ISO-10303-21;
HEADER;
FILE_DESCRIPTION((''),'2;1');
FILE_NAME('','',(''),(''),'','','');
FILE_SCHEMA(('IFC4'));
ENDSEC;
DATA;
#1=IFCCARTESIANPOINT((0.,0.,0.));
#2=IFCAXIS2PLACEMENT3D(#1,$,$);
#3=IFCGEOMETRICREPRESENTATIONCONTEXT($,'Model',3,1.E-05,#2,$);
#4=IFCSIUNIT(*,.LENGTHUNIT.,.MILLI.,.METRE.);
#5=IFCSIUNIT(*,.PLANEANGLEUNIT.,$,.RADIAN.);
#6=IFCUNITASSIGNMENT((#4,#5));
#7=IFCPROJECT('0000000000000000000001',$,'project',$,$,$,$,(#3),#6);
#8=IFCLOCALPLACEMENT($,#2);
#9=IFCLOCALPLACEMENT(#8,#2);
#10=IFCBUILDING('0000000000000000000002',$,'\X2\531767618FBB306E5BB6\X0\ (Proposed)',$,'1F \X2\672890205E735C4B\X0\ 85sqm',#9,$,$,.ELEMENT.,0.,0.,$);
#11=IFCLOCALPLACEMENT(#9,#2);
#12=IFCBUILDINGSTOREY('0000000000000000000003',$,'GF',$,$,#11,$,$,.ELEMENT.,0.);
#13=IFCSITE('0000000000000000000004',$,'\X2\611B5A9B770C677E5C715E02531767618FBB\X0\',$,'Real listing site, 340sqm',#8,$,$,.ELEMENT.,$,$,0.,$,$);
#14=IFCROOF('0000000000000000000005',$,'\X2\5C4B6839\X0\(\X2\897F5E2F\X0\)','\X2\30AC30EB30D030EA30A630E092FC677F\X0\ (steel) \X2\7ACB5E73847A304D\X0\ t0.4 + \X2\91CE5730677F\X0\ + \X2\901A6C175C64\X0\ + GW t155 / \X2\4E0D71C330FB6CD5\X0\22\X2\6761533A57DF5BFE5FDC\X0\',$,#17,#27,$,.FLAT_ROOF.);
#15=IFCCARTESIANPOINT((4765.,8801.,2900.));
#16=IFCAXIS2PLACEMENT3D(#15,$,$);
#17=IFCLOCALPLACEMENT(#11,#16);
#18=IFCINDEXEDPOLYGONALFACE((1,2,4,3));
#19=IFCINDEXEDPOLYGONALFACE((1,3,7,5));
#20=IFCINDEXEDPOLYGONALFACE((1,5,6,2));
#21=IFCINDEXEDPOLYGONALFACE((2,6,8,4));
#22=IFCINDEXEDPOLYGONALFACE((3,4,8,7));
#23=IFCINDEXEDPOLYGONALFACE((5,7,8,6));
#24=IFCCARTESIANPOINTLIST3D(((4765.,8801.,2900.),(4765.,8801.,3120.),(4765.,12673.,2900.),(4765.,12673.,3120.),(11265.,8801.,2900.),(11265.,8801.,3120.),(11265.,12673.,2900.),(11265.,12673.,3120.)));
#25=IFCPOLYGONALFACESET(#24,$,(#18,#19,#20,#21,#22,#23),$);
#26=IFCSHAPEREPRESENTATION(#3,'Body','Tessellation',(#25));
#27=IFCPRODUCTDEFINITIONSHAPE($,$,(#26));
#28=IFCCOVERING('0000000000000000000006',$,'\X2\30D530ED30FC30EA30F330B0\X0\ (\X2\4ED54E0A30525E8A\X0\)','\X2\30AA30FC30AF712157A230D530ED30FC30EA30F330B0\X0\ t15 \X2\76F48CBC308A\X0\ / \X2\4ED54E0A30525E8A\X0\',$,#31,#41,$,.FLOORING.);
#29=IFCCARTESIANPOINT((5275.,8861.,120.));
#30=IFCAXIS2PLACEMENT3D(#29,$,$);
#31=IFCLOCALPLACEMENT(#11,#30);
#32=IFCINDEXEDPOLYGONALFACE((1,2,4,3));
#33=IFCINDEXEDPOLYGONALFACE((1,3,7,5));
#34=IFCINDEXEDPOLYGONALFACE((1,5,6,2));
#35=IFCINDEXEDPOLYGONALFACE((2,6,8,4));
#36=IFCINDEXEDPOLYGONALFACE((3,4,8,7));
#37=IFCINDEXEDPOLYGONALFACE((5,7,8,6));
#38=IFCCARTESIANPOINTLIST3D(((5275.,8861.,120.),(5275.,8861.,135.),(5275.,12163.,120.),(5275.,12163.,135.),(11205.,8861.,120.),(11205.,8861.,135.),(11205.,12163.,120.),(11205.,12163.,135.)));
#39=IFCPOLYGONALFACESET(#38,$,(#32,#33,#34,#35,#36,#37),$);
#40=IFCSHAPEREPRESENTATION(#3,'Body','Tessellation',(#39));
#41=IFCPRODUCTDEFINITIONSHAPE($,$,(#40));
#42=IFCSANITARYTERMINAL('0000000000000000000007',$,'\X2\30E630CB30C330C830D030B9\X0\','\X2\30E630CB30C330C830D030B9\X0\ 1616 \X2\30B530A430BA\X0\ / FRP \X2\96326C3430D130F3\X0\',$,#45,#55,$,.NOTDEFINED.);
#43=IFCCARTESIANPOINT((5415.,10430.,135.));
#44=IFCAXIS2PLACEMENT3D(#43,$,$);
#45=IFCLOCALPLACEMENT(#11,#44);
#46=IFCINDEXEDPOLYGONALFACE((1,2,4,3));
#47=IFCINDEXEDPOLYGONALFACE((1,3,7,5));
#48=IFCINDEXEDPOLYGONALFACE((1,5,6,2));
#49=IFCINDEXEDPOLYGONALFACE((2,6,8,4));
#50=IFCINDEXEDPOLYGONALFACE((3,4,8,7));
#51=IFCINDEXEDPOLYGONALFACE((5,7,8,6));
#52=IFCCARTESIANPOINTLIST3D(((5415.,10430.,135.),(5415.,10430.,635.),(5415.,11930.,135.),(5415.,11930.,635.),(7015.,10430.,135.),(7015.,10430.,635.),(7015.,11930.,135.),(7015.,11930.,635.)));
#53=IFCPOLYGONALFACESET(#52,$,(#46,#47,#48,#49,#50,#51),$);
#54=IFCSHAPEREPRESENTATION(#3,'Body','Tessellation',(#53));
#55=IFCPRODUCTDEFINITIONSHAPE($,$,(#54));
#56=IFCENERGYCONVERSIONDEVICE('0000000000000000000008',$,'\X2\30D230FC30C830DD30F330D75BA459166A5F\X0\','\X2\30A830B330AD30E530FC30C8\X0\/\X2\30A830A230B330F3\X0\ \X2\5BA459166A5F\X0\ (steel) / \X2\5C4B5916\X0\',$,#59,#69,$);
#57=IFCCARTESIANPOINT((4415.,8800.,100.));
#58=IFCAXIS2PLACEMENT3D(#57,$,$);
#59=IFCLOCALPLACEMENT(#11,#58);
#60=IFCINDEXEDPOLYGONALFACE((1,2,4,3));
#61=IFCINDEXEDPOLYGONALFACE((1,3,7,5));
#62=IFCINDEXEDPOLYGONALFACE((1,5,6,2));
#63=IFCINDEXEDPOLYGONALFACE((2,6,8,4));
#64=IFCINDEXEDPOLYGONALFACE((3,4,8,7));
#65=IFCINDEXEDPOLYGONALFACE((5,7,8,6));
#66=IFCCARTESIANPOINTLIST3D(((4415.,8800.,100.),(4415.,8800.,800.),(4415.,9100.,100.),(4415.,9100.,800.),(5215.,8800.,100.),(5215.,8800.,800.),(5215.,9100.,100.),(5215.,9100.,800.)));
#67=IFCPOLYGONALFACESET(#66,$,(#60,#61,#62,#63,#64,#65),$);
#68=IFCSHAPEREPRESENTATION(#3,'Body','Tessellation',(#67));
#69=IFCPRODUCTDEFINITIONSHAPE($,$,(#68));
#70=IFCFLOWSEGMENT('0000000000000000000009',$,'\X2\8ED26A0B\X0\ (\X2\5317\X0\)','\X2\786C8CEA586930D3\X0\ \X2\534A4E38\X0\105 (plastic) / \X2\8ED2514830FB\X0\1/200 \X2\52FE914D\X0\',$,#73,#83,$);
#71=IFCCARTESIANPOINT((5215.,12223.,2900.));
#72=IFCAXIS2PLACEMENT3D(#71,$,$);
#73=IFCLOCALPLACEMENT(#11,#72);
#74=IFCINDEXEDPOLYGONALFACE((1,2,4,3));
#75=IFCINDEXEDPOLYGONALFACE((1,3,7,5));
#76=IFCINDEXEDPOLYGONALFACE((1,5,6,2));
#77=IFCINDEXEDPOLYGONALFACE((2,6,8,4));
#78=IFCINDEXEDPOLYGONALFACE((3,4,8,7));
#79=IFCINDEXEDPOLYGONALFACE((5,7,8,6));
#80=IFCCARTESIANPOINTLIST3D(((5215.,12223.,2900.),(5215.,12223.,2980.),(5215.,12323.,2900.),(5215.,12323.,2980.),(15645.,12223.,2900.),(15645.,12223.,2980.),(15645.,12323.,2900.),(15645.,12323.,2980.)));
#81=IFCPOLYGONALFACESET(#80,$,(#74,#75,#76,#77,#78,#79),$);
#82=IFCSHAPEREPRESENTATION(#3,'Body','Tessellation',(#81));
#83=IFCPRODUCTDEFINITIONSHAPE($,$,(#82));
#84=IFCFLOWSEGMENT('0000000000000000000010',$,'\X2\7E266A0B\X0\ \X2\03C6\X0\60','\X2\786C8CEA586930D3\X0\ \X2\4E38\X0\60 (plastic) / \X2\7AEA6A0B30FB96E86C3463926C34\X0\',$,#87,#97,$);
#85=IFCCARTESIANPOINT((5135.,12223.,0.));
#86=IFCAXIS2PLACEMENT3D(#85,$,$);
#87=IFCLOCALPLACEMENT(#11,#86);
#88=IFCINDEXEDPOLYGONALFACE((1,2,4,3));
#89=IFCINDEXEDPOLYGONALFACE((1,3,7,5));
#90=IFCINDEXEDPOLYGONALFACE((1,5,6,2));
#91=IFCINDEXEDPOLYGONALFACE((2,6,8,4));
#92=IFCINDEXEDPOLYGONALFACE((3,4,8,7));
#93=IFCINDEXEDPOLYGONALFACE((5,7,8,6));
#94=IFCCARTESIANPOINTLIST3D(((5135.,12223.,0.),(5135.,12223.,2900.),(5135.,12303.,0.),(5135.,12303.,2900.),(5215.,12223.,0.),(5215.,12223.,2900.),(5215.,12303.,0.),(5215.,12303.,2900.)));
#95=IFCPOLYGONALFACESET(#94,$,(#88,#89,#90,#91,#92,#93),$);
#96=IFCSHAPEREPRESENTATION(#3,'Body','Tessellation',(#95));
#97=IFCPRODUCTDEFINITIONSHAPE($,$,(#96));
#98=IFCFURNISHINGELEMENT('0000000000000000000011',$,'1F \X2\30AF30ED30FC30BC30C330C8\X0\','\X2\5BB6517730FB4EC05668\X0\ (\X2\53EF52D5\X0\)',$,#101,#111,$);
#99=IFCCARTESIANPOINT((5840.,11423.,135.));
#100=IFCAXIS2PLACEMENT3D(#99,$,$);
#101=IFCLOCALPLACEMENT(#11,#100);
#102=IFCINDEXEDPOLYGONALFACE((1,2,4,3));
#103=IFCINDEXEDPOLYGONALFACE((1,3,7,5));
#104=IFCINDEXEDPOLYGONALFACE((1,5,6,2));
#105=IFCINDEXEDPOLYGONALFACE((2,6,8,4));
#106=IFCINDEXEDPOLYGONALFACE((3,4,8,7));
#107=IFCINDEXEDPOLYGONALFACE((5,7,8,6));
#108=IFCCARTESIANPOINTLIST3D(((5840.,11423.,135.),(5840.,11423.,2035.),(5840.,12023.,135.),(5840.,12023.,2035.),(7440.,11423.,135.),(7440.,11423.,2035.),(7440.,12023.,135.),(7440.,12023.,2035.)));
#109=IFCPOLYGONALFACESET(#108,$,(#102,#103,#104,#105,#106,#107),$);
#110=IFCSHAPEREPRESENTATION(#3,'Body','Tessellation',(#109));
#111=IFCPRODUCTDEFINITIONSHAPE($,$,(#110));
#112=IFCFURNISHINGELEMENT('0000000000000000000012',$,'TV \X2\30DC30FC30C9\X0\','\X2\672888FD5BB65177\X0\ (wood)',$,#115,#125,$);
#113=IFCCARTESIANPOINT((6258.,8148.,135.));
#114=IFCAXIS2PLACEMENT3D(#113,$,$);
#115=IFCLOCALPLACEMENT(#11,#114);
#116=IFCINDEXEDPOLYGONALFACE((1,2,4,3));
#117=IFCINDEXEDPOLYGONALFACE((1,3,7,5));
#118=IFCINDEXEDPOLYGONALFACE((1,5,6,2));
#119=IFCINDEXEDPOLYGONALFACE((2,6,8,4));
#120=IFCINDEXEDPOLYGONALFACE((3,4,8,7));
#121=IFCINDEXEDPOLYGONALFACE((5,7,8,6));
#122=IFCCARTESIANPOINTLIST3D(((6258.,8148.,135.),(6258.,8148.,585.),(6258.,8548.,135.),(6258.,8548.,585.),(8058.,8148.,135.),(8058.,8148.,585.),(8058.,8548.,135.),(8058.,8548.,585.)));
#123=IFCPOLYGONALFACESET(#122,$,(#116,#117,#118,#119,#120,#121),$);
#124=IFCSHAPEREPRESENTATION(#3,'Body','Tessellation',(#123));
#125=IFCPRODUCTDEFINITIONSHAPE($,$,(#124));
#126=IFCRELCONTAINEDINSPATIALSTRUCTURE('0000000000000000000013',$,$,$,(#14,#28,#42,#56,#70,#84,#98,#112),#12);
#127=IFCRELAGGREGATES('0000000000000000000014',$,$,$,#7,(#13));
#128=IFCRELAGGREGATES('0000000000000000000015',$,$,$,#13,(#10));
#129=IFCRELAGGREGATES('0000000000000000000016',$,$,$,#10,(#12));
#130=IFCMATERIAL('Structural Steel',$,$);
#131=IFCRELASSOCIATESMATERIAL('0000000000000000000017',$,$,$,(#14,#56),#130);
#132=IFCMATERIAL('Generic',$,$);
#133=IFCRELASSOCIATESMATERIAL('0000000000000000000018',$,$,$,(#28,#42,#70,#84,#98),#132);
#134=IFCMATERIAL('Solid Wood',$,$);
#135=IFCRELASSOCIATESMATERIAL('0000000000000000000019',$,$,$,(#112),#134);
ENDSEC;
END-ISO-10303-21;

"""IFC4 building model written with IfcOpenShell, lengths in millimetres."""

from ifc_helpers import new_model, si_unit, frame, frame_2d, origin, place, context, project, spatial, rectangle, extrude, material, element, save


model = new_model("IFC4")

# Units and contexts
model_context = context("Model", 3, precision=1e-05, world=origin())
ifc_project = project(units=[si_unit("LENGTHUNIT", "METRE", prefix="MILLI"), si_unit("PLANEANGLEUNIT", "RADIAN")], contexts=[model_context])

# Site, building, storey
site_placement = place(None, origin())
site = spatial("IfcSite", under=ifc_project, at=site_placement, Name="愛媛県松山市北条辻", ObjectType="Real listing site, 340sqm", CompositionType="ELEMENT", RefElevation=0.0)
building_placement = place(site_placement, origin())
building = spatial("IfcBuilding", under=site, at=building_placement, Name="北条辻の家 (Proposed)", ObjectType="1F 木造平屋 85sqm", CompositionType="ELEMENT", ElevationOfRefHeight=0.0, ElevationOfTerrain=0.0)
storey_placement = place(building_placement, origin())
storey = spatial("IfcBuildingStorey", under=building, at=storey_placement, Name="GF", CompositionType="ELEMENT", Elevation=0.0)

# Shared definitions
ifc_material_1 = material(Name="Solid Wood")

# Roof
ifc_material_2 = material(Name="Structural Steel")
roof_placement = place(storey_placement, frame((4765.0, 8801.0, 2900.0)))
element("IfcRoof", 1, at=roof_placement, inside=storey, material=ifc_material_2, Name="屋根(西帯)", Description="ガルバリウム鋼板 (steel) 立平葺き t0.4 + 野地板 + 通気層 + GW t155 / 不燃・法22条区域対応", PredefinedType="FLAT_ROOF", context=model_context, shape_type="SweptSolid", body=[
    extrude(rectangle(XDim=6500.0, YDim=3872.0, at=frame_2d((3250.0, 1936.0))), frame((4765.0, 8801.0, 2900.0)), (0.0, 0.0, 1.0), 220.0),
])

# Covering
ifc_material_3 = material(Name="Generic")
covering_placement = place(storey_placement, frame((5275.0, 8861.0, 120.0)))
element("IfcCovering", 2, at=covering_placement, inside=storey, material=ifc_material_3, Name="フローリング (仕上げ床)", Description="オーク無垢フローリング t15 直貼り / 仕上げ床", PredefinedType="FLOORING", context=model_context, shape_type="SweptSolid", body=[
    extrude(rectangle(XDim=5930.0, YDim=3302.0, at=frame_2d((2965.0, 1651.0))), frame((5275.0, 8861.0, 120.0)), (0.0, 0.0, 1.0), 15.0),
])

# Sanitary terminal
sanitary_terminal_placement = place(storey_placement, frame((5415.0, 10430.0, 135.0)))
element("IfcSanitaryTerminal", 3, at=sanitary_terminal_placement, inside=storey, material=ifc_material_3, Name="ユニットバス", Description="ユニットバス 1616 サイズ / FRP 防水パン", PredefinedType="NOTDEFINED", context=model_context, shape_type="SweptSolid", body=[
    extrude(rectangle(XDim=1600.0, YDim=1500.0, at=frame_2d((800.0, 750.0))), frame((5415.0, 10430.0, 135.0)), (0.0, 0.0, 1.0), 500.0),
])

# Energy conversion device
energy_conversion_device_placement = place(storey_placement, frame((4415.0, 8800.0, 100.0)))
element("IfcEnergyConversionDevice", 4, at=energy_conversion_device_placement, inside=storey, material=ifc_material_2, Name="ヒートポンプ室外機", Description="エコキュート/エアコン 室外機 (steel) / 屋外", context=model_context, shape_type="SweptSolid", body=[
    extrude(rectangle(XDim=800.0, YDim=300.0, at=frame_2d((400.0, 150.0))), frame((4415.0, 8800.0, 100.0)), (0.0, 0.0, 1.0), 700.0),
])

# Flow segments
flow_segment_1_placement = place(storey_placement, frame((5215.0, 12223.0, 2900.0)))
element("IfcFlowSegment", 5, at=flow_segment_1_placement, inside=storey, material=ifc_material_3, Name="軒樋 (北)", Description="硬質塩ビ 半丸105 (plastic) / 軒先・1/200 勾配", context=model_context, shape_type="SweptSolid", body=[
    extrude(rectangle(XDim=10430.0, YDim=100.0, at=frame_2d((5215.0, 50.0))), frame((5215.0, 12223.0, 2900.0)), (0.0, 0.0, 1.0), 80.0),
])
flow_segment_2_placement = place(storey_placement, frame((5135.0, 12223.0, 0.0)))
element("IfcFlowSegment", 6, at=flow_segment_2_placement, inside=storey, material=ifc_material_3, Name="縦樋 φ60", Description="硬質塩ビ 丸60 (plastic) / 竪樋・雨水排水", context=model_context, shape_type="SweptSolid", body=[
    extrude(rectangle(XDim=80.0, YDim=80.0, at=frame_2d((40.0, 40.0))), frame((5135.0, 12223.0, 0.0)), (0.0, 0.0, 1.0), 2900.0),
])

# Furnishing elements
furnishing_1_placement = place(storey_placement, frame((5840.0, 11423.0, 135.0)))
element("IfcFurnishingElement", 7, at=furnishing_1_placement, inside=storey, material=ifc_material_3, Name="1F クローゼット", Description="家具・什器 (可動)", context=model_context, shape_type="SweptSolid", body=[
    extrude(rectangle(XDim=1600.0, YDim=600.0, at=frame_2d((800.0, 300.0))), frame((5840.0, 11423.0, 135.0)), (0.0, 0.0, 1.0), 1900.0),
])
furnishing_2_placement = place(storey_placement, frame((6258.0, 8148.0, 135.0)))
element("IfcFurnishingElement", 8, at=furnishing_2_placement, inside=storey, material=ifc_material_1, Name="TV ボード", Description="木製家具 (wood)", context=model_context, shape_type="SweptSolid", body=[
    extrude(rectangle(XDim=1800.0, YDim=400.0, at=frame_2d((900.0, 200.0))), frame((6258.0, 8148.0, 135.0)), (0.0, 0.0, 1.0), 450.0),
])

save(model, "model.ifc")
